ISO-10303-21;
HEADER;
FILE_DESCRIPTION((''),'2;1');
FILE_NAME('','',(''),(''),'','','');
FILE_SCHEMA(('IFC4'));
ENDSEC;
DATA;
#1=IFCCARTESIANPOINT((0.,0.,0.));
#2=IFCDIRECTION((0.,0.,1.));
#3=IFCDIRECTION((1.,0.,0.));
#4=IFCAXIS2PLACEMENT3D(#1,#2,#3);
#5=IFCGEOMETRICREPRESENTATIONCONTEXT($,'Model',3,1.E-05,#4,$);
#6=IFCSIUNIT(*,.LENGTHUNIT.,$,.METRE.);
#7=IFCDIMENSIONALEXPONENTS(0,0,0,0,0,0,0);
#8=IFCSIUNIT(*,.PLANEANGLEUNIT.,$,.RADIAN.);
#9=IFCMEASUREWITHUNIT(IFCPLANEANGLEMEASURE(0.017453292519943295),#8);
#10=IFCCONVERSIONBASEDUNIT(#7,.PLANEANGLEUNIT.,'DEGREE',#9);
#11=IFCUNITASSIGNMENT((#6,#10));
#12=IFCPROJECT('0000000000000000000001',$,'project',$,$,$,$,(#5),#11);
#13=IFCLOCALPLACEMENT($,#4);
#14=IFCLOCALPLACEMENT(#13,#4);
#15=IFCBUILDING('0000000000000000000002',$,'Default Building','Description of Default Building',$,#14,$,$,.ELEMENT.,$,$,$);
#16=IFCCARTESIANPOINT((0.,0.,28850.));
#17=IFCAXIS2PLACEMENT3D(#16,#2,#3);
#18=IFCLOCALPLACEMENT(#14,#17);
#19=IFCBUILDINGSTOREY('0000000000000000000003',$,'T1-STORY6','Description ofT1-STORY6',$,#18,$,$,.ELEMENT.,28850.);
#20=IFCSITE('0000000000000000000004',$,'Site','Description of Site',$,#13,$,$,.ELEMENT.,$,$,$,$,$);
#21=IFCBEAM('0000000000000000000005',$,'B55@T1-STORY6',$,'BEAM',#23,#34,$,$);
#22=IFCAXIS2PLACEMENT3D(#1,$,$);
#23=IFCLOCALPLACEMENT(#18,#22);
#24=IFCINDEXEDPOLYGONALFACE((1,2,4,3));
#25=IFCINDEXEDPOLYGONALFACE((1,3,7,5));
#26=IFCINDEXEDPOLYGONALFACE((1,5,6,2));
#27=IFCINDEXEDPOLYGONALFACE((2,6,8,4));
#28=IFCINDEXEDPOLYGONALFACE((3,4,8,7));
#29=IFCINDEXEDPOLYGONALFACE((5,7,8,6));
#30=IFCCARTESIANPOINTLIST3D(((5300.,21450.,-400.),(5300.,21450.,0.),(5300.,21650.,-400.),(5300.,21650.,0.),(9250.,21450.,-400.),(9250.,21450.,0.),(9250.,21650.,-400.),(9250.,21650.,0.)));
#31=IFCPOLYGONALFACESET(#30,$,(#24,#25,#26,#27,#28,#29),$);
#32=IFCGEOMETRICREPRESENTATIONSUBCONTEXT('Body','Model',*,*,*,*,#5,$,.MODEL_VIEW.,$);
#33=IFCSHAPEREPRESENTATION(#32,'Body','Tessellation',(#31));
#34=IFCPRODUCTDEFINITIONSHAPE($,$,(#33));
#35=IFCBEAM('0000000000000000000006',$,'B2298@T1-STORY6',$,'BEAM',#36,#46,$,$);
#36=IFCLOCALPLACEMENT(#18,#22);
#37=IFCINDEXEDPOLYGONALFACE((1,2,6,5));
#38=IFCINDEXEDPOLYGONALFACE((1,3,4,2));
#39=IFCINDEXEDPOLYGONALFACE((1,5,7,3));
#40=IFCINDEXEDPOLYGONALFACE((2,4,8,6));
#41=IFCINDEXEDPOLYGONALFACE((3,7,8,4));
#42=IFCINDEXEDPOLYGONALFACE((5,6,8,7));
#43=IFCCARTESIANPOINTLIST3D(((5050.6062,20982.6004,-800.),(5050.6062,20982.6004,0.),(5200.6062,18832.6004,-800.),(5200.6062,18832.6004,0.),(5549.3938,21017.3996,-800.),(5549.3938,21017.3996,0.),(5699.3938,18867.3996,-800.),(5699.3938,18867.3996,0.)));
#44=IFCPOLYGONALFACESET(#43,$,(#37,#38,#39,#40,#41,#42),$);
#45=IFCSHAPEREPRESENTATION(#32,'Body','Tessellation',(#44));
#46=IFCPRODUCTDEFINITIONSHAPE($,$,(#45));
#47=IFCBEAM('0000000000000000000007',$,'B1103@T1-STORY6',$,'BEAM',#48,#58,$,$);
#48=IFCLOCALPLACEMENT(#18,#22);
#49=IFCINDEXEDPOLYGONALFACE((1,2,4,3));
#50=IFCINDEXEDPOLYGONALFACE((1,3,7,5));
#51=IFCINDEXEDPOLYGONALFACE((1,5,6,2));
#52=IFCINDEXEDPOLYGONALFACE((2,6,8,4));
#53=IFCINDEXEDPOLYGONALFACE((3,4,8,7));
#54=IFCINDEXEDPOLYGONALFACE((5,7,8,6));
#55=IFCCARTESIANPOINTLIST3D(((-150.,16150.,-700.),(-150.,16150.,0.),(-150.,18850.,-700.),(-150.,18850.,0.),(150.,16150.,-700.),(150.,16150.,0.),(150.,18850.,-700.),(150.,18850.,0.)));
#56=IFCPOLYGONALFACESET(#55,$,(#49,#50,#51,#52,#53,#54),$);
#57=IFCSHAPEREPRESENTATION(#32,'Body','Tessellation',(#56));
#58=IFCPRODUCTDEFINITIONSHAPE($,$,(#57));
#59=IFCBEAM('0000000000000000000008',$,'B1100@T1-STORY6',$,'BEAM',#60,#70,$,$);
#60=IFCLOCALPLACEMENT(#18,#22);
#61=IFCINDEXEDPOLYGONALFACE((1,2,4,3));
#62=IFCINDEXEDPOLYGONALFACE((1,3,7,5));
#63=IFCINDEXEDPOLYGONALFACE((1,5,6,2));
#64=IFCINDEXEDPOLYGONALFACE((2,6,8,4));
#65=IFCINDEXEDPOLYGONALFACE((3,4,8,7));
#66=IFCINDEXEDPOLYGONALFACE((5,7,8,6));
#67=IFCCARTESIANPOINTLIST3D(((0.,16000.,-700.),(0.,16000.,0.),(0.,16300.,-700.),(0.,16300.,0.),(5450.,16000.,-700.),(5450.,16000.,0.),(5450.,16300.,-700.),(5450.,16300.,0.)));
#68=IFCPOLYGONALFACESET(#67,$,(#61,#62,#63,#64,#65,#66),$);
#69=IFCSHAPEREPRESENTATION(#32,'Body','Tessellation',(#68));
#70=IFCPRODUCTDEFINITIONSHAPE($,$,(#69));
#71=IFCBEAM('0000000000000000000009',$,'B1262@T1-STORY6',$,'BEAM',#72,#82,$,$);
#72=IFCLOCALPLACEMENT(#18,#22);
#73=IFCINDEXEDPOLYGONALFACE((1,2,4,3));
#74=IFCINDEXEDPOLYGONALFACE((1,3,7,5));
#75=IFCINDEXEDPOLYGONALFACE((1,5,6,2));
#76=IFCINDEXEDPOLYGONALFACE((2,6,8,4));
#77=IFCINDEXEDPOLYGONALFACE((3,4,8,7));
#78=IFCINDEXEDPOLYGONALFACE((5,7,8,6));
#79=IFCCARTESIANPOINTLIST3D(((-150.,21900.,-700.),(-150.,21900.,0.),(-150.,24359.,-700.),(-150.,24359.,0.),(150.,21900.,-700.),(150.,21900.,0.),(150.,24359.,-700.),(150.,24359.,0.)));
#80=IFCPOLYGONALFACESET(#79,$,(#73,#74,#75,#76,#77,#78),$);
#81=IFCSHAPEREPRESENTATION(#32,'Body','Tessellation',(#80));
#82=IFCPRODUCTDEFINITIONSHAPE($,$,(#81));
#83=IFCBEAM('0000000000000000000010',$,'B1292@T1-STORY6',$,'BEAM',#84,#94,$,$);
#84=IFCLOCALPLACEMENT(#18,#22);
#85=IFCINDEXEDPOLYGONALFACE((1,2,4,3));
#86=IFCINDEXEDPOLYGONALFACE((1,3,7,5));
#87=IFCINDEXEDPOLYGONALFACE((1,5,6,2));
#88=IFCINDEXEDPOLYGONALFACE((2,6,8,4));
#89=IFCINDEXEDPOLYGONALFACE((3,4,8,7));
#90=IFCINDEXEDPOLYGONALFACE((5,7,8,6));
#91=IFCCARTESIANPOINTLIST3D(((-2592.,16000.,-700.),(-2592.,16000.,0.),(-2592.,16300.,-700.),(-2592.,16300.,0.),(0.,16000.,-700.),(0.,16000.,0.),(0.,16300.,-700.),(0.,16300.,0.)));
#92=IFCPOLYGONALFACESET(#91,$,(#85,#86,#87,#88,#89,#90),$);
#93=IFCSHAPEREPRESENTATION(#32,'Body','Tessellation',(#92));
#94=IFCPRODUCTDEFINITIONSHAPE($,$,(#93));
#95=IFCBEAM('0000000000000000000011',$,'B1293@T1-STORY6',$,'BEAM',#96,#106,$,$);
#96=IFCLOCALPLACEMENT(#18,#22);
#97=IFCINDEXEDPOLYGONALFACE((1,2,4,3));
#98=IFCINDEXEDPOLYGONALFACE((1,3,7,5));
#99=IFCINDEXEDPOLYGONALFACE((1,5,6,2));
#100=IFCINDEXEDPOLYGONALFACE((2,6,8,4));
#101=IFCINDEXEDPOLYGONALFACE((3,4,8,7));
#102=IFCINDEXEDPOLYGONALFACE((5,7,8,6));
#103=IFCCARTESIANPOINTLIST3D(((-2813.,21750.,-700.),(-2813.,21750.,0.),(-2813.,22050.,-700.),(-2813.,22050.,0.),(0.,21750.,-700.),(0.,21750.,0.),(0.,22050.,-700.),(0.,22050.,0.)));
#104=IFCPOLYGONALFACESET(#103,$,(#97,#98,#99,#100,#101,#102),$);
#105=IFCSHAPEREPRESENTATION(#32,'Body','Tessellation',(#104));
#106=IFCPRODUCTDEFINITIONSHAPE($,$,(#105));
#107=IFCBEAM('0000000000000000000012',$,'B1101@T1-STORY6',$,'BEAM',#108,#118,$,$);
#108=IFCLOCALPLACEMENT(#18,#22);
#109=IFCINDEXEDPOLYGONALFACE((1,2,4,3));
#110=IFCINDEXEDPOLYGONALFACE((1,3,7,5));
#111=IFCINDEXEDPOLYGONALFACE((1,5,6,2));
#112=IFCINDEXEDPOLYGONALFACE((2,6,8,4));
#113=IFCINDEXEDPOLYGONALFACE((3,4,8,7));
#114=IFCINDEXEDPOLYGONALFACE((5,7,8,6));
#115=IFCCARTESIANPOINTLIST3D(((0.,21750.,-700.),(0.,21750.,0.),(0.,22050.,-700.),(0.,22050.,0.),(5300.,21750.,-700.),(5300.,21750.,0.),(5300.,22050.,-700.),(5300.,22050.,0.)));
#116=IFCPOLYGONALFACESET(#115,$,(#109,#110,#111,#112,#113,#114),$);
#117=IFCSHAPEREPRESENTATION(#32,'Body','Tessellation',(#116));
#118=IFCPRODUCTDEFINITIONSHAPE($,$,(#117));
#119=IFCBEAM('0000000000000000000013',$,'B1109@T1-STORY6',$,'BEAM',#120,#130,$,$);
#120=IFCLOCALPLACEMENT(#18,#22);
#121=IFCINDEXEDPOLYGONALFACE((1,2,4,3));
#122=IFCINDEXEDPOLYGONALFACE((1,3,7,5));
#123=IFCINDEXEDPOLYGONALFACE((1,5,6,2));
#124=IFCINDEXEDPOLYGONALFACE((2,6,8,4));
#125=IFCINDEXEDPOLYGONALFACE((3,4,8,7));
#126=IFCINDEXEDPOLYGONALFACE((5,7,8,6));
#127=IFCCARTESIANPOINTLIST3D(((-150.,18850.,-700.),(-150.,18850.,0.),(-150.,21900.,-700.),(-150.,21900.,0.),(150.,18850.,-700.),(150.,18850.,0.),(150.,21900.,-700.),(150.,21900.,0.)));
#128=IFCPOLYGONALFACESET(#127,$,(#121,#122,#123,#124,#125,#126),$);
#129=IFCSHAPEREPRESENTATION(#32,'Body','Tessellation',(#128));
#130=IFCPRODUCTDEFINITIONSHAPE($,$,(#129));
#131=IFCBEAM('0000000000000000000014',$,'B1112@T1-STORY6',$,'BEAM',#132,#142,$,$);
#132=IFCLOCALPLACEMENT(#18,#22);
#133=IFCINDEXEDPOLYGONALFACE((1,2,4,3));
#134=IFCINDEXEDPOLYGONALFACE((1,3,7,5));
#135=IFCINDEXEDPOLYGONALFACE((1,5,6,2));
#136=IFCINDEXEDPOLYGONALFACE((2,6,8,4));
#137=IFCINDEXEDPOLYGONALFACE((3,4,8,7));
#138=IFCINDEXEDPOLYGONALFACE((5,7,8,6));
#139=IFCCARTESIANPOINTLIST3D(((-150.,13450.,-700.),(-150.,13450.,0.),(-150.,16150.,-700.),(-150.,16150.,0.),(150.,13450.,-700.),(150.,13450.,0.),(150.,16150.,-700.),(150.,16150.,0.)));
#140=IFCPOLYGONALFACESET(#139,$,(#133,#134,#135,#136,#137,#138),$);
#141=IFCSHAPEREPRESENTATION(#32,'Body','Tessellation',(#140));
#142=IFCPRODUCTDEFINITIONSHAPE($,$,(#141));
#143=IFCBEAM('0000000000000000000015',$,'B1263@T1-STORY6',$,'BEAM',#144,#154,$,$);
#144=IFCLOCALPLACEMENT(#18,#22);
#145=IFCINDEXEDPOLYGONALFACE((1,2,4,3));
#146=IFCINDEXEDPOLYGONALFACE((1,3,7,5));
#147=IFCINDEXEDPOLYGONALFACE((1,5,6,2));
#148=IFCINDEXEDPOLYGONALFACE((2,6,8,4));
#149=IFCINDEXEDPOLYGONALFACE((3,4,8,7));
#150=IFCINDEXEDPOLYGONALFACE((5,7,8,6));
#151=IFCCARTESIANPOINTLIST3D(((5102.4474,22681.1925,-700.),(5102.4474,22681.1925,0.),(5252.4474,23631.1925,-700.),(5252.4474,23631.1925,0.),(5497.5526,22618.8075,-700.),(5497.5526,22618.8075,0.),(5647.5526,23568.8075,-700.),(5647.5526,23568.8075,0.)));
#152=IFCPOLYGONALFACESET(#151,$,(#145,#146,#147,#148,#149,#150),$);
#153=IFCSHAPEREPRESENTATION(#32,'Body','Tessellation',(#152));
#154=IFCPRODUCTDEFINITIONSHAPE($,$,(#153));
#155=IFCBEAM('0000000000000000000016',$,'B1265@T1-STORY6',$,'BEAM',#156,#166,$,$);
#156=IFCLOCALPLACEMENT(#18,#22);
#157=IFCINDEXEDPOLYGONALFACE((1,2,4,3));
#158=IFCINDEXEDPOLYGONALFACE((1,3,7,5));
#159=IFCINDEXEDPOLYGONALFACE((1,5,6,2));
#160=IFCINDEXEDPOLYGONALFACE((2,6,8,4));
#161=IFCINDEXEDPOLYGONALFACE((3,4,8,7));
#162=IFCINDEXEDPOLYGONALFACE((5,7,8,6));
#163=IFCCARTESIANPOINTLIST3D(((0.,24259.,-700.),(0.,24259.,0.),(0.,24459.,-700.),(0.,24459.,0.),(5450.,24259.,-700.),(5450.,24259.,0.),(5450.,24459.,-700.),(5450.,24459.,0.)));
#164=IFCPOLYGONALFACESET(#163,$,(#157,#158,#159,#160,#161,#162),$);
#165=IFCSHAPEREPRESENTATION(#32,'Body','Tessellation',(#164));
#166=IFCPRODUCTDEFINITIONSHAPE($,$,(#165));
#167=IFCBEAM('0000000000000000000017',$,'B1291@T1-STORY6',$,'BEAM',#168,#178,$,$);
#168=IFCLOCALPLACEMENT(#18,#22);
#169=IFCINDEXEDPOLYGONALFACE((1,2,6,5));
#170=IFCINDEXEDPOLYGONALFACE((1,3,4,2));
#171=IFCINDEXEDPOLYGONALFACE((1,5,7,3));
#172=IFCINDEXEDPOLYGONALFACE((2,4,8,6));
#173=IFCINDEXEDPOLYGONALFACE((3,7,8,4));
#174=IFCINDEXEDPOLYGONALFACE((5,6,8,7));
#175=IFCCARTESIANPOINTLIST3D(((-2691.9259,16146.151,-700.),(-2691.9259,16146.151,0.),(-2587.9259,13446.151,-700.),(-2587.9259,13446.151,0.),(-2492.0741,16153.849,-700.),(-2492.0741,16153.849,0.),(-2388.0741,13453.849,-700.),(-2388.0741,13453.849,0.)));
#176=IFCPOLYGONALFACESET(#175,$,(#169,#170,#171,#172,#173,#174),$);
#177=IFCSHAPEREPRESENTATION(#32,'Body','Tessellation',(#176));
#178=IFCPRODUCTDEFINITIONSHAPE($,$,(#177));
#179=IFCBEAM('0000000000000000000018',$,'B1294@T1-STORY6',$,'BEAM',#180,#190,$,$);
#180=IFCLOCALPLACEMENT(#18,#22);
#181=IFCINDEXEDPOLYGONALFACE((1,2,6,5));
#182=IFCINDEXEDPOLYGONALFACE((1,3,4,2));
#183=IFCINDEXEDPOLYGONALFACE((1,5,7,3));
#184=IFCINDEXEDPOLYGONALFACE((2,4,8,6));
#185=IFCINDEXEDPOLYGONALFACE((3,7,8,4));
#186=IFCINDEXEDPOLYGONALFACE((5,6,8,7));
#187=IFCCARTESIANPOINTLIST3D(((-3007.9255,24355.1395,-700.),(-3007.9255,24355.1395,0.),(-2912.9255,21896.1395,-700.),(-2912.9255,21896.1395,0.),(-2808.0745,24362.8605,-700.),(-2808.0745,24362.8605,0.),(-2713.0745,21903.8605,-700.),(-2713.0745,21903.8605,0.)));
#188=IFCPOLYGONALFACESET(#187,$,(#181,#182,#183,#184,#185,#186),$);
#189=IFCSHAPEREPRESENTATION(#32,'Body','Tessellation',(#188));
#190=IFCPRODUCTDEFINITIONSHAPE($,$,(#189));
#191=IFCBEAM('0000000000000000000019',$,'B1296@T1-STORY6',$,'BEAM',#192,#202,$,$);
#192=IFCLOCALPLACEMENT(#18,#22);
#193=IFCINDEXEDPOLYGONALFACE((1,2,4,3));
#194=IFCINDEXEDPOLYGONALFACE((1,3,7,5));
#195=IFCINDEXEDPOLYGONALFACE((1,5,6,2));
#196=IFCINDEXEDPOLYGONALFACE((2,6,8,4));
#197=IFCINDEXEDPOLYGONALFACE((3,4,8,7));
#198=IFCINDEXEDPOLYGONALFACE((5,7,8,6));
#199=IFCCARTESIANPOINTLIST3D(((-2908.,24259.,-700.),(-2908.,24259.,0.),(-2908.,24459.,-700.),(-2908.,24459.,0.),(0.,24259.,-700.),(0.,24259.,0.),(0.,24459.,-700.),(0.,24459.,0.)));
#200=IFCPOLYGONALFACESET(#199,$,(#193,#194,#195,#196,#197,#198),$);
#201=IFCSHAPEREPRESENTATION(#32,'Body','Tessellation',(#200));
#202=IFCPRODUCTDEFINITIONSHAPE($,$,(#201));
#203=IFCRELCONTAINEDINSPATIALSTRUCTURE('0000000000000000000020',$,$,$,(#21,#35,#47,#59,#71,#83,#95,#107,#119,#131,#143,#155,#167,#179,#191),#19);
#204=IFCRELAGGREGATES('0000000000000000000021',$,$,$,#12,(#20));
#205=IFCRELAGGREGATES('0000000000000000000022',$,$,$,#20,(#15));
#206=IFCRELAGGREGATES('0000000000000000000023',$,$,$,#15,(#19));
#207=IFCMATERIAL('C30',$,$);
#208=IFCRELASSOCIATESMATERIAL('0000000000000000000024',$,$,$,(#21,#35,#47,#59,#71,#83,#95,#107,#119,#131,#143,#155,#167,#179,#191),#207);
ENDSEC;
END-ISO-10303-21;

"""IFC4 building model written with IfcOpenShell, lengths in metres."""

from ifc_helpers import new_model, entity, si_unit, converted_unit, frame, origin_with_axes, place, context, subcontext, project, spatial, rectangle, extrude, material, element, save


model = new_model("IFC4")

# Units and contexts
model_context = context("Model", 3, precision=1e-05, world=origin_with_axes())
body_context = subcontext(model_context, "Body", "Model", "MODEL_VIEW")
ifc_project = project(units=[si_unit("LENGTHUNIT", "METRE"), converted_unit("PLANEANGLEUNIT", "DEGREE", entity("IfcPlaneAngleMeasure", 0.017453292519943295), si_unit("PLANEANGLEUNIT", "RADIAN"), dimensions=[0, 0, 0, 0, 0, 0, 0])], contexts=[model_context])

# Site, building, storey
site_placement = place(None, origin_with_axes())
site = spatial("IfcSite", under=ifc_project, at=site_placement, Name="Site", Description="Description of Site", CompositionType="ELEMENT")
building_placement = place(site_placement, origin_with_axes())
building = spatial("IfcBuilding", under=site, at=building_placement, Name="Default Building", Description="Description of Default Building", CompositionType="ELEMENT")
storey_placement = place(building_placement, frame((0.0, 0.0, 28850.0), z_axis=(0.0, 0.0, 1.0), x_axis=(1.0, 0.0, 0.0)))
storey = spatial("IfcBuildingStorey", under=building, at=storey_placement, Name="T1-STORY6", Description="Description ofT1-STORY6", CompositionType="ELEMENT", Elevation=28850.0)

# Beams
ifc_material_1 = material(Name="C30")
beam_1_placement = place(storey_placement, frame((5300.0, 21550.0, -200.0), z_axis=(1.0, 0.0, 0.0), x_axis=(0.0, 1.0, 0.0)))
element("IfcBeam", 1, at=beam_1_placement, inside=storey, material=ifc_material_1, Name="B55@T1-STORY6", ObjectType="BEAM", context=body_context, shape_type="SweptSolid", body=[
    extrude(rectangle(XDim=200.0, YDim=400.0), origin_with_axes(), (0.0, 0.0, 1.0), 3950.0),
])
beam_2_placement = place(storey_placement, frame((5300.0, 21000.0, -400.0), z_axis=(0.069598, -0.997575, 0.0), x_axis=(0.997575, 0.069598, 0.0)))
element("IfcBeam", 2, at=beam_2_placement, inside=storey, material=ifc_material_1, Name="B2298@T1-STORY6", ObjectType="BEAM", context=body_context, shape_type="SweptSolid", body=[
    extrude(rectangle(XDim=500.0, YDim=800.0), origin_with_axes(), (0.0, 0.0, 1.0), 2155.2262),
])
beam_3_placement = place(storey_placement, frame((0.0, 16150.0, -350.0), z_axis=(0.0, 1.0, 0.0), x_axis=(-1.0, 0.0, 0.0)))
element("IfcBeam", 3, at=beam_3_placement, inside=storey, material=ifc_material_1, Name="B1103@T1-STORY6", ObjectType="BEAM", context=body_context, shape_type="SweptSolid", body=[
    extrude(rectangle(XDim=300.0, YDim=700.0), origin_with_axes(), (0.0, 0.0, 1.0), 2700.0),
])
beam_4_placement = place(storey_placement, frame((0.0, 16150.0, -350.0), z_axis=(1.0, 0.0, 0.0), x_axis=(0.0, 1.0, 0.0)))
element("IfcBeam", 4, at=beam_4_placement, inside=storey, material=ifc_material_1, Name="B1100@T1-STORY6", ObjectType="BEAM", context=body_context, shape_type="SweptSolid", body=[
    extrude(rectangle(XDim=300.0, YDim=700.0), origin_with_axes(), (0.0, 0.0, 1.0), 5450.0),
])
beam_5_placement = place(storey_placement, frame((0.0, 21900.0, -350.0), z_axis=(0.0, 1.0, 0.0), x_axis=(-1.0, 0.0, 0.0)))
element("IfcBeam", 5, at=beam_5_placement, inside=storey, material=ifc_material_1, Name="B1262@T1-STORY6", ObjectType="BEAM", context=body_context, shape_type="SweptSolid", body=[
    extrude(rectangle(XDim=300.0, YDim=700.0), origin_with_axes(), (0.0, 0.0, 1.0), 2459.0),
])
beam_6_placement = place(storey_placement, frame((-2592.0, 16150.0, -350.0), z_axis=(1.0, 0.0, 0.0), x_axis=(0.0, 1.0, 0.0)))
element("IfcBeam", 6, at=beam_6_placement, inside=storey, material=ifc_material_1, Name="B1292@T1-STORY6", ObjectType="BEAM", context=body_context, shape_type="SweptSolid", body=[
    extrude(rectangle(XDim=300.0, YDim=700.0), origin_with_axes(), (0.0, 0.0, 1.0), 2592.0),
])
beam_7_placement = place(storey_placement, frame((-2813.0, 21900.0, -350.0), z_axis=(1.0, 0.0, 0.0), x_axis=(0.0, 1.0, 0.0)))
element("IfcBeam", 7, at=beam_7_placement, inside=storey, material=ifc_material_1, Name="B1293@T1-STORY6", ObjectType="BEAM", context=body_context, shape_type="SweptSolid", body=[
    extrude(rectangle(XDim=300.0, YDim=700.0), origin_with_axes(), (0.0, 0.0, 1.0), 2813.0),
])
beam_8_placement = place(storey_placement, frame((0.0, 21900.0, -350.0), z_axis=(1.0, 0.0, 0.0), x_axis=(0.0, 1.0, 0.0)))
element("IfcBeam", 8, at=beam_8_placement, inside=storey, material=ifc_material_1, Name="B1101@T1-STORY6", ObjectType="BEAM", context=body_context, shape_type="SweptSolid", body=[
    extrude(rectangle(XDim=300.0, YDim=700.0), origin_with_axes(), (0.0, 0.0, 1.0), 5300.0),
])
beam_9_placement = place(storey_placement, frame((0.0, 18850.0, -350.0), z_axis=(0.0, 1.0, 0.0), x_axis=(-1.0, 0.0, 0.0)))
element("IfcBeam", 9, at=beam_9_placement, inside=storey, material=ifc_material_1, Name="B1109@T1-STORY6", ObjectType="BEAM", context=body_context, shape_type="SweptSolid", body=[
    extrude(rectangle(XDim=300.0, YDim=700.0), origin_with_axes(), (0.0, 0.0, 1.0), 3050.0),
])
beam_10_placement = place(storey_placement, frame((0.0, 13450.0, -350.0), z_axis=(0.0, 1.0, 0.0), x_axis=(-1.0, 0.0, 0.0)))
element("IfcBeam", 10, at=beam_10_placement, inside=storey, material=ifc_material_1, Name="B1112@T1-STORY6", ObjectType="BEAM", context=body_context, shape_type="SweptSolid", body=[
    extrude(rectangle(XDim=300.0, YDim=700.0), origin_with_axes(), (0.0, 0.0, 1.0), 2700.0),
])
beam_11_placement = place(storey_placement, frame((5300.0, 22650.0, -350.0), z_axis=(0.155963, 0.987763, 0.0), x_axis=(-0.987763, 0.155963, 0.0)))
element("IfcBeam", 11, at=beam_11_placement, inside=storey, material=ifc_material_1, Name="B1263@T1-STORY6", ObjectType="BEAM", context=body_context, shape_type="SweptSolid", body=[
    extrude(rectangle(XDim=400.0, YDim=700.0), origin_with_axes(), (0.0, 0.0, 1.0), 961.7692),
])
beam_12_placement = place(storey_placement, frame((0.0, 24359.0, -350.0), z_axis=(1.0, 0.0, 0.0), x_axis=(0.0, 1.0, 0.0)))
element("IfcBeam", 12, at=beam_12_placement, inside=storey, material=ifc_material_1, Name="B1265@T1-STORY6", ObjectType="BEAM", context=body_context, shape_type="SweptSolid", body=[
    extrude(rectangle(XDim=200.0, YDim=700.0), origin_with_axes(), (0.0, 0.0, 1.0), 5450.0),
])
beam_13_placement = place(storey_placement, frame((-2592.0, 16150.0, -350.0), z_axis=(0.03849, -0.999259, 0.0), x_axis=(0.999259, 0.03849, 0.0)))
element("IfcBeam", 13, at=beam_13_placement, inside=storey, material=ifc_material_1, Name="B1291@T1-STORY6", ObjectType="BEAM", context=body_context, shape_type="SweptSolid", body=[
    extrude(rectangle(XDim=200.0, YDim=700.0), origin_with_axes(), (0.0, 0.0, 1.0), 2702.0022),
])
beam_14_placement = place(storey_placement, frame((-2908.0, 24359.0, -350.0), z_axis=(0.038605, -0.999255, 0.0), x_axis=(0.999255, 0.038605, 0.0)))
element("IfcBeam", 14, at=beam_14_placement, inside=storey, material=ifc_material_1, Name="B1294@T1-STORY6", ObjectType="BEAM", context=body_context, shape_type="SweptSolid", body=[
    extrude(rectangle(XDim=200.0, YDim=700.0), origin_with_axes(), (0.0, 0.0, 1.0), 2460.8344),
])
beam_15_placement = place(storey_placement, frame((-2908.0, 24359.0, -350.0), z_axis=(1.0, 0.0, 0.0), x_axis=(0.0, 1.0, 0.0)))
element("IfcBeam", 15, at=beam_15_placement, inside=storey, material=ifc_material_1, Name="B1296@T1-STORY6", ObjectType="BEAM", context=body_context, shape_type="SweptSolid", body=[
    extrude(rectangle(XDim=200.0, YDim=700.0), origin_with_axes(), (0.0, 0.0, 1.0), 2908.0),
])

save(model, "model.ifc")
